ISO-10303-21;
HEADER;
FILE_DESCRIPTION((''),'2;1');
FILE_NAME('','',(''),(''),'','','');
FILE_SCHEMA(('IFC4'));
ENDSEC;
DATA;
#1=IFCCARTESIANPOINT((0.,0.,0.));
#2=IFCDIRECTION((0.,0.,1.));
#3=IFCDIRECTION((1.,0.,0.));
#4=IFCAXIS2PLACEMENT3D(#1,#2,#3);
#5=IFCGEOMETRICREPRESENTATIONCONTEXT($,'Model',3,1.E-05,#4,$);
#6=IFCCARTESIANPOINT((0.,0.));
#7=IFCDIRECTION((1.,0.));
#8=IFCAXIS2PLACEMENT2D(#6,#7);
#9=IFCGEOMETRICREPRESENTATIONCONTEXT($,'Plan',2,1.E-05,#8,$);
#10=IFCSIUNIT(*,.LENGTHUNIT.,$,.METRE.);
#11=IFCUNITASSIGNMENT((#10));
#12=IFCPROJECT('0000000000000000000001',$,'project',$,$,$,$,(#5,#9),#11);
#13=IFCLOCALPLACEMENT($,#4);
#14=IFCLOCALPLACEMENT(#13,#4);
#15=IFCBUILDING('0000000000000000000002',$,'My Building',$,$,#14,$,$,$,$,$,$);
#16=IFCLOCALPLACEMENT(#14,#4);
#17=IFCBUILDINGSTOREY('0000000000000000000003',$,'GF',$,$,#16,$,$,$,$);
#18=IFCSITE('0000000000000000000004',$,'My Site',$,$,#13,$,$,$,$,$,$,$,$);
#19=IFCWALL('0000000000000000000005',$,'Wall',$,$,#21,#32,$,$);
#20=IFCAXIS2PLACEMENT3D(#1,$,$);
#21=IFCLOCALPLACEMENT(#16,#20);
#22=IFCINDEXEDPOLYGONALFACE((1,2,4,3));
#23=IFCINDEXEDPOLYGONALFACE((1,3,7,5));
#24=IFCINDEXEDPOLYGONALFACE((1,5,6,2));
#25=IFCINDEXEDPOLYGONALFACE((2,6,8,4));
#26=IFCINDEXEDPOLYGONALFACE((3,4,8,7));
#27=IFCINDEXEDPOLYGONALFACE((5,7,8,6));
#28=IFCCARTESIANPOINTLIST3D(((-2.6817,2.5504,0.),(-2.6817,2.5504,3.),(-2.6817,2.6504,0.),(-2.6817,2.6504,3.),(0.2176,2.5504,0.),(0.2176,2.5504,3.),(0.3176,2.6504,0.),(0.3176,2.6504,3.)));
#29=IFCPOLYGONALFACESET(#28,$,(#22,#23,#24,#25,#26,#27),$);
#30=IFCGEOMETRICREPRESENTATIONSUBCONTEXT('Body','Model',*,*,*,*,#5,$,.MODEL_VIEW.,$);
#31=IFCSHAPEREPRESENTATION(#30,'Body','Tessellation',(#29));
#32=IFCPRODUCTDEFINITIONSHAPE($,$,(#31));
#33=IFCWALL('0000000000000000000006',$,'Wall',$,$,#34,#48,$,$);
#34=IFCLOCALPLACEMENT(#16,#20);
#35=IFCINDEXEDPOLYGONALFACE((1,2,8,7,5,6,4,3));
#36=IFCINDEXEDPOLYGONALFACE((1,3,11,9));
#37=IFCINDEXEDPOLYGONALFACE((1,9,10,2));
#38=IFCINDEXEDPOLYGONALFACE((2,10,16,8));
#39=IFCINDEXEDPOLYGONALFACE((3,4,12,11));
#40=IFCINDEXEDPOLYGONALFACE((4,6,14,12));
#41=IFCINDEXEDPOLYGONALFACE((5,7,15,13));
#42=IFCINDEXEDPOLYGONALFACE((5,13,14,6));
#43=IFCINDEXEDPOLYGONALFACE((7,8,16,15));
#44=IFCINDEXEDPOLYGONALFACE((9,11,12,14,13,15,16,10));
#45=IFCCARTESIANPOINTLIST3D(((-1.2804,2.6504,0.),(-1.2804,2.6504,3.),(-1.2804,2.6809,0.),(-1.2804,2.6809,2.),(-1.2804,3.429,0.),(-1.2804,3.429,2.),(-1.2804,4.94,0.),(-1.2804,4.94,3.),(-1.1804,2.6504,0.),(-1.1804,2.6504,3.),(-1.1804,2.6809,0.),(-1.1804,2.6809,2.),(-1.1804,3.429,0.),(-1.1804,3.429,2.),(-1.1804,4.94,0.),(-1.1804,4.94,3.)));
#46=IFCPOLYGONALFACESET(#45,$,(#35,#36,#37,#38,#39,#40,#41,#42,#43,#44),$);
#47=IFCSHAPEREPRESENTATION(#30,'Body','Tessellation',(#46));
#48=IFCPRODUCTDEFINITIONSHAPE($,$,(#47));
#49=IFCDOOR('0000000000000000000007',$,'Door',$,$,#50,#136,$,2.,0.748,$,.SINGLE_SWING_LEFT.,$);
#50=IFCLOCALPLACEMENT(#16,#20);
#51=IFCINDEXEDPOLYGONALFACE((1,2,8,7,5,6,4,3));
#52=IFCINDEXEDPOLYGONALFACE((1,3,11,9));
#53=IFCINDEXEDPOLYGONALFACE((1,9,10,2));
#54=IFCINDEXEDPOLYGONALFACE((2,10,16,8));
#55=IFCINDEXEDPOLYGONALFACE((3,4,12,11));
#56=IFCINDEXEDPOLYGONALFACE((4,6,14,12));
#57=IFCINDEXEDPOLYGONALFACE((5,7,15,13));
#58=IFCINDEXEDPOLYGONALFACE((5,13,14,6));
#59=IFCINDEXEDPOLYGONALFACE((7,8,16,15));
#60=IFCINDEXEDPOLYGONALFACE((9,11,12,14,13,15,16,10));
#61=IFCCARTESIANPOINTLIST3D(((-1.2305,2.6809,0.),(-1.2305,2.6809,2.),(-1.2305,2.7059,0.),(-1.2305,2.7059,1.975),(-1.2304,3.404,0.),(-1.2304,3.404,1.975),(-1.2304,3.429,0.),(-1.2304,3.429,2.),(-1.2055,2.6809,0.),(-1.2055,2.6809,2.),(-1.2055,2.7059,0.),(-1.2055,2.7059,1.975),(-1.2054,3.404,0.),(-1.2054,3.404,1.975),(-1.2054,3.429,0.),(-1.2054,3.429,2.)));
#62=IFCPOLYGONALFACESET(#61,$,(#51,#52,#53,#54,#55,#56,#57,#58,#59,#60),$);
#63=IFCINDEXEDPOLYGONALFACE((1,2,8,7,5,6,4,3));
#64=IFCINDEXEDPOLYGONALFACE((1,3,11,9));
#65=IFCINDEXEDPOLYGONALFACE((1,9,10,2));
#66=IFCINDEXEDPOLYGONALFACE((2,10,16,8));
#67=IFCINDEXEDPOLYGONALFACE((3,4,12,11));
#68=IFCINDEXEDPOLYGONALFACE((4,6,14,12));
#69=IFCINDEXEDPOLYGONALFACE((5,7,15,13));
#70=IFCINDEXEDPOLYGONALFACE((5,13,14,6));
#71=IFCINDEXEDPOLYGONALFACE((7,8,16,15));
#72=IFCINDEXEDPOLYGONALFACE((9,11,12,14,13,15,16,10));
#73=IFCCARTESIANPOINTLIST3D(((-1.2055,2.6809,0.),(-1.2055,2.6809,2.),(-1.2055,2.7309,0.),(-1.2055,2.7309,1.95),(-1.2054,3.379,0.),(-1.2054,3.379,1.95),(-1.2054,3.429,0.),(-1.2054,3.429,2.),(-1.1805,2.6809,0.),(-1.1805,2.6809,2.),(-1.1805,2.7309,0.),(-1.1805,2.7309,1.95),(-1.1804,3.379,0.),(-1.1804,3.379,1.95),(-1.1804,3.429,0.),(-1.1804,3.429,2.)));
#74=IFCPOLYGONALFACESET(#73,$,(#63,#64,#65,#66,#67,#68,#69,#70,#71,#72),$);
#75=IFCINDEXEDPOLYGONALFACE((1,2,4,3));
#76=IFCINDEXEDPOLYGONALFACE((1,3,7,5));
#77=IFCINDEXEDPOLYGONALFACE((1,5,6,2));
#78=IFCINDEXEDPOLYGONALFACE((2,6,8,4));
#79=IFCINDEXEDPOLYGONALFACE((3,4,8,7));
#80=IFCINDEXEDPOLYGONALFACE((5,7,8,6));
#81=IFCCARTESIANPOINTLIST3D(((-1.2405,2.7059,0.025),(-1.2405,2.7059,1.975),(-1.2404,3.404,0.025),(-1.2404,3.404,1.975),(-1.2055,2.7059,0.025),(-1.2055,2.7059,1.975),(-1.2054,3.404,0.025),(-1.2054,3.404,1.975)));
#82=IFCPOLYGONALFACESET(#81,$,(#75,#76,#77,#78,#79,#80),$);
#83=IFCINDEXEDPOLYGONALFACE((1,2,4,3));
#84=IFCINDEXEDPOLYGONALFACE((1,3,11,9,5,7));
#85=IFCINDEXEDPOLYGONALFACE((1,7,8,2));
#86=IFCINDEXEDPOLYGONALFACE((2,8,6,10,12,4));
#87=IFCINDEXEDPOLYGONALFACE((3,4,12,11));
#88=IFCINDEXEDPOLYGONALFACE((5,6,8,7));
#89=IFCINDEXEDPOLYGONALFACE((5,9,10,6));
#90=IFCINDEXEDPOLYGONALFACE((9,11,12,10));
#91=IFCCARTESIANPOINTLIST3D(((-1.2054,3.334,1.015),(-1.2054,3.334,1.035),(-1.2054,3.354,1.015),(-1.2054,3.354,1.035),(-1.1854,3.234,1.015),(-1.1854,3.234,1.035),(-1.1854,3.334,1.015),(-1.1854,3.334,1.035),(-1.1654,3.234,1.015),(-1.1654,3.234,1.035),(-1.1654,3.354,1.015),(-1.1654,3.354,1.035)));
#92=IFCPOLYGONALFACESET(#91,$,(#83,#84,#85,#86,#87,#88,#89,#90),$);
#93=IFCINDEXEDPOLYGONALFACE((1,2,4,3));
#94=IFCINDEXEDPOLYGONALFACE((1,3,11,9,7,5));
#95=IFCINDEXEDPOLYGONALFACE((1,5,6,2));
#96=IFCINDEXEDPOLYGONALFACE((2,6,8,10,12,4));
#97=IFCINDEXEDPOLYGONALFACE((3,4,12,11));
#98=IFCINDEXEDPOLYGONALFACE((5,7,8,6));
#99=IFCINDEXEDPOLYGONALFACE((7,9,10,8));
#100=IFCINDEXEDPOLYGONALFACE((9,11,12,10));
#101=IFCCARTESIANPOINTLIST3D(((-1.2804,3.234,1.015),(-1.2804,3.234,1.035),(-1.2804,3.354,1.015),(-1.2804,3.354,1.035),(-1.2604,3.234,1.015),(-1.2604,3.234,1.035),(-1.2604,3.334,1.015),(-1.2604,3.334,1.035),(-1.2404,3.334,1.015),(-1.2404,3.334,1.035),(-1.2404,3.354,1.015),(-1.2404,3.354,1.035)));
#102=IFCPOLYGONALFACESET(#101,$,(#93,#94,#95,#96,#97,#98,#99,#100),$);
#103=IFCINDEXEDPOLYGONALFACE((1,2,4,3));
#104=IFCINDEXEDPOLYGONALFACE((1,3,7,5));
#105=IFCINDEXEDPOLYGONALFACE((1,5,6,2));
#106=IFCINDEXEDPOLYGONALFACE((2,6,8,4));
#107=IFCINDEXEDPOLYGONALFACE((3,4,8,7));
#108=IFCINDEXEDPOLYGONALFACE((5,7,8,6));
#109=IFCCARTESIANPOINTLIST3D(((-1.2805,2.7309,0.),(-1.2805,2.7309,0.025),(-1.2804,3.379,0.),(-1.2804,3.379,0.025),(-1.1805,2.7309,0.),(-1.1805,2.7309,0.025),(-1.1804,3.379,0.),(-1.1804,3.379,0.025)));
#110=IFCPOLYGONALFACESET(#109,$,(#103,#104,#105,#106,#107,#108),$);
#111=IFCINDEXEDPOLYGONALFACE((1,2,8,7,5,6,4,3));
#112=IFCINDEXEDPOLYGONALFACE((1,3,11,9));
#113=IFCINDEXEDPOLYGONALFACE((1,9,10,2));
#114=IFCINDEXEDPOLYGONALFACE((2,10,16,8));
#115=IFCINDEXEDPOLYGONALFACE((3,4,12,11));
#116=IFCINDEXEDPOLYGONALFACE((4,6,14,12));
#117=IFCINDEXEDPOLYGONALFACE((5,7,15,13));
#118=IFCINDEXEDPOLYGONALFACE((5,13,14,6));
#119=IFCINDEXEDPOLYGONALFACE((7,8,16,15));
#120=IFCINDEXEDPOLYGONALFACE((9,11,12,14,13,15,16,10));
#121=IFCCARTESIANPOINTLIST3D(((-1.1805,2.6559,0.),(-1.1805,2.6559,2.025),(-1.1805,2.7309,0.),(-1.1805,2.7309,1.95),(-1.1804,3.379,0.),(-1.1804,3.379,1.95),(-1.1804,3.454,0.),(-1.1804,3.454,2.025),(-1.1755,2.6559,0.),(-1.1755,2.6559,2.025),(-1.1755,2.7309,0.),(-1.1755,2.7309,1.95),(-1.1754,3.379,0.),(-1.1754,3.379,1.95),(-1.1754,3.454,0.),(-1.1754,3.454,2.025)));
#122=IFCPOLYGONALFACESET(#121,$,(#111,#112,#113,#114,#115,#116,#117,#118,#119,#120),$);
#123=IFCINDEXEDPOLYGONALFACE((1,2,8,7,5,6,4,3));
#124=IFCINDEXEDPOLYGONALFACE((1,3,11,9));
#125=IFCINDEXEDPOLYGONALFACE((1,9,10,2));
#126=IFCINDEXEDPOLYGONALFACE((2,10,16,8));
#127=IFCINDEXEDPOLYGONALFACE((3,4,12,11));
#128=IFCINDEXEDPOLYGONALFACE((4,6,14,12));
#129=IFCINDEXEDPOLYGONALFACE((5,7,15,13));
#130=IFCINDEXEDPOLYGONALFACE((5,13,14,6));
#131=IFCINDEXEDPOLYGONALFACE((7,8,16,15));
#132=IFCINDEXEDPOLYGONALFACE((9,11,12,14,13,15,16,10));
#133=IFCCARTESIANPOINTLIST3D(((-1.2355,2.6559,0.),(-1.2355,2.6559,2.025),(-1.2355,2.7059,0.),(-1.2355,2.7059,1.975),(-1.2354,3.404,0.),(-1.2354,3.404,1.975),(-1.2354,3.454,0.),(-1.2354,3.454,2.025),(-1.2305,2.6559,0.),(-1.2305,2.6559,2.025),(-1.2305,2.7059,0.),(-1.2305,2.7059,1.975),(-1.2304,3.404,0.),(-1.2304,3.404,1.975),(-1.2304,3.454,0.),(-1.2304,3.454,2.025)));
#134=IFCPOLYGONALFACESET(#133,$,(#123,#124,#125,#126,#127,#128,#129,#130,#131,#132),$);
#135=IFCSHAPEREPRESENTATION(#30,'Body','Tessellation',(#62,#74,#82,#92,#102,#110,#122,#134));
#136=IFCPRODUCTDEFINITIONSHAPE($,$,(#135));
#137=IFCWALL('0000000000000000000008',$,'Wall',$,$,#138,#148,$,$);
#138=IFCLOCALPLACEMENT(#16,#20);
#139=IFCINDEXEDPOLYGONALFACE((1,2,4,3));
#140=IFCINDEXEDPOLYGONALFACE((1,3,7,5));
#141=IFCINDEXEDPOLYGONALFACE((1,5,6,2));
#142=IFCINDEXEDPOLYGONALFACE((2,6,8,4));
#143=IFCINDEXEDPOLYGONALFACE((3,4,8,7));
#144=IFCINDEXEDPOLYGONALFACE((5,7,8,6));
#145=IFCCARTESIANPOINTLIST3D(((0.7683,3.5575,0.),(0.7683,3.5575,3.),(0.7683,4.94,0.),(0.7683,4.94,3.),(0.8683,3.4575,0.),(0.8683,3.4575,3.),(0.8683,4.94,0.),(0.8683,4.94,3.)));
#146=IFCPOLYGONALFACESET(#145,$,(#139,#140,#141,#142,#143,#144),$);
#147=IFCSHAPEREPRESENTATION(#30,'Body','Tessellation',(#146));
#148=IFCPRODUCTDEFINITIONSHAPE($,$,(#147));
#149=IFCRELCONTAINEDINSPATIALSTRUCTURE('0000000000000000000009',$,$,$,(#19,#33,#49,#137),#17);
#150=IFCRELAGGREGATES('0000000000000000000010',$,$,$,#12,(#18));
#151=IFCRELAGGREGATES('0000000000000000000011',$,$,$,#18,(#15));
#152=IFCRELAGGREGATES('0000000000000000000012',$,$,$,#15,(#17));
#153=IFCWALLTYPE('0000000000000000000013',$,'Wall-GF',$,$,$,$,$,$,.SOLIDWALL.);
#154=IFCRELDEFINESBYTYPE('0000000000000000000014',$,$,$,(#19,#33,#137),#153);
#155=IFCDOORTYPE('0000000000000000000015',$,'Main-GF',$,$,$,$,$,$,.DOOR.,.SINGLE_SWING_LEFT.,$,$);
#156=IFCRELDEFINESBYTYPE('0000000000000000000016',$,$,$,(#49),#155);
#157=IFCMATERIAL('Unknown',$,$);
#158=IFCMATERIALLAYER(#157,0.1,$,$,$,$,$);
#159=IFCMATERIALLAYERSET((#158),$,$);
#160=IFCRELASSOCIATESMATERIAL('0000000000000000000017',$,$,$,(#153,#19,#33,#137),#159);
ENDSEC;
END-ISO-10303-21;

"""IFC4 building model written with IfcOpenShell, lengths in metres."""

from ifc_helpers import new_model, entity, si_unit, frame, origin_with_axes, origin_2d_with_axis, place, context, subcontext, project, spatial, line, indexed_curve, outline, extrude, shape, source, transform, mapped, material, layer, layer_set, layer_usage, type_object, type_shapes, element, fill, save


model = new_model("IFC4")

# Units and contexts
model_context = context("Model", 3, precision=1e-05, world=origin_with_axes())
plan_context = context("Plan", 2, precision=1e-05, world=origin_2d_with_axis())
body_context_1 = subcontext(model_context, "Body", "Model", "MODEL_VIEW")
body_context_2 = subcontext(plan_context, "Body", "Plan", "PLAN_VIEW")
ifc_project = project(units=[si_unit("LENGTHUNIT", "METRE")], contexts=[model_context, plan_context])

# Site, building, storey
site_placement = place(None, origin_with_axes())
site = spatial("IfcSite", under=ifc_project, at=site_placement, Name="My Site")
building_placement = place(site_placement, origin_with_axes())
building = spatial("IfcBuilding", under=site, at=building_placement, Name="My Building")
storey_placement = place(building_placement, origin_with_axes())
storey = spatial("IfcBuildingStorey", under=building, at=storey_placement, Name="GF")

# Shared definitions
ifc_material_1 = material(Name="Unknown")

# Shared definitions
ifc_layer_1 = layer(ifc_material_1, 0.1)
ifc_layer_set_1 = layer_set([ifc_layer_1])
wall_type = type_object("IfcWallType", Name="Wall-GF", PredefinedType="SOLIDWALL", material=ifc_layer_set_1)

# Wall
ifc_layer_usage_1 = layer_usage(ifc_layer_set_1, "AXIS2", "POSITIVE", 0.0)
wall_1_placement = place(storey_placement, frame((0.3176, 2.6504, 0.0), z_axis=(0.0, 0.0, 1.0), x_axis=(-1.0, 0.0, 0.0)))
element("IfcWall", 1, at=wall_1_placement, inside=storey, type_object=wall_type, material=ifc_layer_usage_1, Name="Wall", context=body_context_1, shape_type="SweptSolid", body=[
    extrude(outline(indexed_curve([(0.0, 0.0), (0.1, 0.1), (2.9992, 0.1), (2.9992, 0.0)], segments=[line(1, 2, 3, 4, 1)])), origin_with_axes(), (0.0, 0.0, 1.0), 3.0),
])

# Wall, opening, door
ifc_layer_usage_2 = layer_usage(ifc_layer_set_1, "AXIS2", "POSITIVE", 0.0)
wall_2_placement = place(storey_placement, frame((-1.1804, 2.6504, 0.0), z_axis=(0.0, 0.0, 1.0), x_axis=(0.0, 1.0, 0.0)))
wall_2 = element("IfcWall", 2, at=wall_2_placement, inside=storey, type_object=wall_type, material=ifc_layer_usage_2, Name="Wall", context=body_context_1, shape_type="SweptSolid", body=[
    extrude(outline(indexed_curve([(0.0, 0.0), (0.0, 0.1), (2.2896, 0.1), (2.2896, 0.0)], segments=[line(1, 2, 3, 4, 1)])), origin_with_axes(), (0.0, 0.0, 1.0), 3.0),
])
shared_shape_1 = source(origin_with_axes(), body_context_1, "Body", "SweptSolid", [
    extrude(outline(indexed_curve([(0.0, 0.0), (0.748, 0.0), (0.748, 2.0), (0.0, 2.0)], segments=[line(1, 2, 3, 4, 1)])), frame((0.0, -0.6, 0.0), z_axis=(0.0, -1.0, 0.0), x_axis=(1.0, 0.0, 0.0)), (0.0, 0.0, -1.0), 1.2),
])
opening_1_placement = place(wall_2_placement, frame((0.0306, 0.0, 0.0), z_axis=(0.0, 0.0, 1.0), x_axis=(1.0, 0.0, 0.0)))
opening_1 = element("IfcOpeningElement", 3, at=opening_1_placement, cuts=wall_2, PredefinedType="OPENING", context=body_context_1, shape_type="MappedRepresentation", body=[
    mapped(shared_shape_1, transform((0.0, 0.0, 0.0), x_axis=(1.0, 0.0, 0.0), y_axis=(0.0, 1.0, 0.0), z_axis=(0.0, 0.0, 1.0), scale=1.0)),
])
door_type_1 = type_object("IfcDoorType", Name="Main-GF", OperationType="SINGLE_SWING_LEFT", PredefinedType="DOOR")
shared_shape_2 = source(origin_with_axes(), body_context_1, "Body", "SweptSolid", [
    extrude(outline(indexed_curve([(0.0, 0.0), (0.0, 2.0), (0.748, 2.0), (0.748, 0.0), (0.723, 0.0), (0.723, 1.975), (0.025, 1.975), (0.025, 0.0)], segments=[line(1, 2, 3, 4, 5, 6, 7, 8, 1)])), frame((0.0, 0.025, 0.0), z_axis=(0.0, -1.0, 0.0), x_axis=(1.0, 0.0, 0.0)), (0.0, 0.0, -1.0), 0.025),
    extrude(outline(indexed_curve([(0.0, 0.0), (0.0, 2.0), (0.748, 2.0), (0.748, 0.0), (0.698, 0.0), (0.698, 1.95), (0.05, 1.95), (0.05, 0.0)], segments=[line(1, 2, 3, 4, 5, 6, 7, 8, 1)])), frame((0.0, 0.0, 0.0), z_axis=(0.0, -1.0, 0.0), x_axis=(1.0, 0.0, 0.0)), (0.0, 0.0, -1.0), 0.025),
    extrude(outline(indexed_curve([(0.0, 0.0), (0.698, 0.0), (0.698, 0.035), (0.0, 0.035)], segments=[line(1, 2, 3, 4, 1)])), frame((0.025, 0.025, 0.025), z_axis=(0.0, 0.0, 1.0), x_axis=(1.0, 0.0, 0.0)), (0.0, 0.0, 1.0), 1.95),
    extrude(outline(indexed_curve([(0.0, 0.0), (0.0, -0.04), (-0.12, -0.04), (-0.12, -0.02), (-0.02, -0.02), (-0.02, 0.0)], segments=[line(1, 2, 3, 4, 5, 6, 1)])), frame((0.673, 0.025, 1.015), z_axis=(0.0, 0.0, 1.0), x_axis=(1.0, 0.0, 0.0)), (0.0, 0.0, 1.0), 0.02),
    extrude(outline(indexed_curve([(0.0, 0.0), (0.0, 0.04), (-0.12, 0.04), (-0.12, 0.02), (-0.02, 0.02), (-0.02, 0.0)], segments=[line(1, 2, 3, 4, 5, 6, 1)])), frame((0.673, 0.06, 1.015), z_axis=(0.0, 0.0, 1.0), x_axis=(1.0, 0.0, 0.0)), (0.0, 0.0, 1.0), 0.02),
    extrude(outline(indexed_curve([(0.0, 0.0), (0.648, 0.0), (0.648, 0.1), (0.0, 0.1)], segments=[line(1, 2, 3, 4, 1)])), frame((0.05, 0.0, 0.0), z_axis=(0.0, 0.0, 1.0), x_axis=(1.0, 0.0, 0.0)), (0.0, 0.0, 1.0), 0.025),
    extrude(outline(indexed_curve([(0.0, 0.0), (0.0, 2.025), (0.798, 2.025), (0.798, 0.0), (0.723, 0.0), (0.723, 1.95), (0.075, 1.95), (0.075, 0.0)], segments=[line(1, 2, 3, 4, 5, 6, 7, 8, 1)])), frame((-0.025, -0.005, 0.0), z_axis=(0.0, -1.0, 0.0), x_axis=(1.0, 0.0, 0.0)), (0.0, 0.0, -1.0), 0.005),
    extrude(outline(indexed_curve([(0.0, 0.0), (0.0, 2.025), (0.798, 2.025), (0.798, 0.0), (0.748, 0.0), (0.748, 1.975), (0.05, 1.975), (0.05, 0.0)], segments=[line(1, 2, 3, 4, 5, 6, 7, 8, 1)])), frame((-0.025, 0.05, 0.0), z_axis=(0.0, -1.0, 0.0), x_axis=(1.0, 0.0, 0.0)), (0.0, 0.0, -1.0), 0.005),
])
shared_shape_3 = source(origin_with_axes(), body_context_2, "Body", "Curve2D", [
    entity("IfcIndexedPolyCurve", entity("IfcCartesianPointList2D", [[0.0, 0.0], [0.0, 0.05], [0.025, 0.05], [0.025, 0.025], [0.05, 0.025], [0.05, 0.0]]), [entity("IfcLineIndex", [1, 2, 3, 4, 5, 6, 1])]),
    entity("IfcIndexedPolyCurve", entity("IfcCartesianPointList2D", [[0.748, 0.0], [0.748, 0.05], [0.723, 0.05], [0.723, 0.025], [0.698, 0.025], [0.698, 0.0]]), [entity("IfcLineIndex", [1, 2, 3, 4, 5, 6, 1])]),
    entity("IfcTrimmedCurve", entity("IfcEllipse", entity("IfcAxis2Placement2D", entity("IfcCartesianPoint", [0.06, 0.05]), entity("IfcDirection", [1.0, 0.0])), 0.663, 0.698), [entity("IfcCartesianPoint", [0.723, 0.05])], [entity("IfcCartesianPoint", [0.06, 0.748])], True, "CARTESIAN"),
    entity("IfcIndexedPolyCurve", entity("IfcCartesianPointList2D", [[0.025, 0.05], [0.06, 0.05], [0.06, 0.748], [0.025, 0.748]]), [entity("IfcLineIndex", [1, 2, 3, 4, 1])]),
])
type_shapes(door_type_1, [shared_shape_2, shared_shape_3])
door_1_placement = place(opening_1_placement, frame((0.0, 0.0, 0.0), z_axis=(0.0, 0.0, 1.0), x_axis=(1.0, 0.0, 0.0)))
door_1 = element("IfcDoor", 4, at=door_1_placement, inside=storey, type_object=door_type_1, Name="Door", OperationType="SINGLE_SWING_LEFT", OverallHeight=2.0, OverallWidth=0.748, shapes=[
    shape(body_context_1, "Body", "MappedRepresentation", [mapped(shared_shape_2, transform((0.0, 0.0, 0.0), x_axis=(1.0, 0.0, 0.0), y_axis=(0.0, 1.0, 0.0), z_axis=(0.0, 0.0, 1.0), scale=1.0))]),
    shape(body_context_2, "Body", "MappedRepresentation", [mapped(shared_shape_3, transform((0.0, 0.0, 0.0), x_axis=(1.0, 0.0, 0.0), y_axis=(0.0, 1.0, 0.0), z_axis=(0.0, 0.0, 1.0), scale=1.0))]),
])
fill(opening_1, door_1)

# Wall
ifc_layer_usage_3 = layer_usage(ifc_layer_set_1, "AXIS2", "POSITIVE", 0.0)
wall_3_placement = place(storey_placement, frame((0.7683, 5.04, 0.0), z_axis=(0.0, 0.0, 1.0), x_axis=(0.0, -1.0, 0.0)))
element("IfcWall", 5, at=wall_3_placement, inside=storey, type_object=wall_type, material=ifc_layer_usage_3, Name="Wall", context=body_context_1, shape_type="SweptSolid", body=[
    extrude(outline(indexed_curve([(0.1, 0.0), (0.1, 0.1), (1.5825, 0.1), (1.4825, 0.0)], segments=[line(1, 2, 3, 4, 1)])), origin_with_axes(), (0.0, 0.0, 1.0), 3.0),
])

save(model, "model.ifc")
